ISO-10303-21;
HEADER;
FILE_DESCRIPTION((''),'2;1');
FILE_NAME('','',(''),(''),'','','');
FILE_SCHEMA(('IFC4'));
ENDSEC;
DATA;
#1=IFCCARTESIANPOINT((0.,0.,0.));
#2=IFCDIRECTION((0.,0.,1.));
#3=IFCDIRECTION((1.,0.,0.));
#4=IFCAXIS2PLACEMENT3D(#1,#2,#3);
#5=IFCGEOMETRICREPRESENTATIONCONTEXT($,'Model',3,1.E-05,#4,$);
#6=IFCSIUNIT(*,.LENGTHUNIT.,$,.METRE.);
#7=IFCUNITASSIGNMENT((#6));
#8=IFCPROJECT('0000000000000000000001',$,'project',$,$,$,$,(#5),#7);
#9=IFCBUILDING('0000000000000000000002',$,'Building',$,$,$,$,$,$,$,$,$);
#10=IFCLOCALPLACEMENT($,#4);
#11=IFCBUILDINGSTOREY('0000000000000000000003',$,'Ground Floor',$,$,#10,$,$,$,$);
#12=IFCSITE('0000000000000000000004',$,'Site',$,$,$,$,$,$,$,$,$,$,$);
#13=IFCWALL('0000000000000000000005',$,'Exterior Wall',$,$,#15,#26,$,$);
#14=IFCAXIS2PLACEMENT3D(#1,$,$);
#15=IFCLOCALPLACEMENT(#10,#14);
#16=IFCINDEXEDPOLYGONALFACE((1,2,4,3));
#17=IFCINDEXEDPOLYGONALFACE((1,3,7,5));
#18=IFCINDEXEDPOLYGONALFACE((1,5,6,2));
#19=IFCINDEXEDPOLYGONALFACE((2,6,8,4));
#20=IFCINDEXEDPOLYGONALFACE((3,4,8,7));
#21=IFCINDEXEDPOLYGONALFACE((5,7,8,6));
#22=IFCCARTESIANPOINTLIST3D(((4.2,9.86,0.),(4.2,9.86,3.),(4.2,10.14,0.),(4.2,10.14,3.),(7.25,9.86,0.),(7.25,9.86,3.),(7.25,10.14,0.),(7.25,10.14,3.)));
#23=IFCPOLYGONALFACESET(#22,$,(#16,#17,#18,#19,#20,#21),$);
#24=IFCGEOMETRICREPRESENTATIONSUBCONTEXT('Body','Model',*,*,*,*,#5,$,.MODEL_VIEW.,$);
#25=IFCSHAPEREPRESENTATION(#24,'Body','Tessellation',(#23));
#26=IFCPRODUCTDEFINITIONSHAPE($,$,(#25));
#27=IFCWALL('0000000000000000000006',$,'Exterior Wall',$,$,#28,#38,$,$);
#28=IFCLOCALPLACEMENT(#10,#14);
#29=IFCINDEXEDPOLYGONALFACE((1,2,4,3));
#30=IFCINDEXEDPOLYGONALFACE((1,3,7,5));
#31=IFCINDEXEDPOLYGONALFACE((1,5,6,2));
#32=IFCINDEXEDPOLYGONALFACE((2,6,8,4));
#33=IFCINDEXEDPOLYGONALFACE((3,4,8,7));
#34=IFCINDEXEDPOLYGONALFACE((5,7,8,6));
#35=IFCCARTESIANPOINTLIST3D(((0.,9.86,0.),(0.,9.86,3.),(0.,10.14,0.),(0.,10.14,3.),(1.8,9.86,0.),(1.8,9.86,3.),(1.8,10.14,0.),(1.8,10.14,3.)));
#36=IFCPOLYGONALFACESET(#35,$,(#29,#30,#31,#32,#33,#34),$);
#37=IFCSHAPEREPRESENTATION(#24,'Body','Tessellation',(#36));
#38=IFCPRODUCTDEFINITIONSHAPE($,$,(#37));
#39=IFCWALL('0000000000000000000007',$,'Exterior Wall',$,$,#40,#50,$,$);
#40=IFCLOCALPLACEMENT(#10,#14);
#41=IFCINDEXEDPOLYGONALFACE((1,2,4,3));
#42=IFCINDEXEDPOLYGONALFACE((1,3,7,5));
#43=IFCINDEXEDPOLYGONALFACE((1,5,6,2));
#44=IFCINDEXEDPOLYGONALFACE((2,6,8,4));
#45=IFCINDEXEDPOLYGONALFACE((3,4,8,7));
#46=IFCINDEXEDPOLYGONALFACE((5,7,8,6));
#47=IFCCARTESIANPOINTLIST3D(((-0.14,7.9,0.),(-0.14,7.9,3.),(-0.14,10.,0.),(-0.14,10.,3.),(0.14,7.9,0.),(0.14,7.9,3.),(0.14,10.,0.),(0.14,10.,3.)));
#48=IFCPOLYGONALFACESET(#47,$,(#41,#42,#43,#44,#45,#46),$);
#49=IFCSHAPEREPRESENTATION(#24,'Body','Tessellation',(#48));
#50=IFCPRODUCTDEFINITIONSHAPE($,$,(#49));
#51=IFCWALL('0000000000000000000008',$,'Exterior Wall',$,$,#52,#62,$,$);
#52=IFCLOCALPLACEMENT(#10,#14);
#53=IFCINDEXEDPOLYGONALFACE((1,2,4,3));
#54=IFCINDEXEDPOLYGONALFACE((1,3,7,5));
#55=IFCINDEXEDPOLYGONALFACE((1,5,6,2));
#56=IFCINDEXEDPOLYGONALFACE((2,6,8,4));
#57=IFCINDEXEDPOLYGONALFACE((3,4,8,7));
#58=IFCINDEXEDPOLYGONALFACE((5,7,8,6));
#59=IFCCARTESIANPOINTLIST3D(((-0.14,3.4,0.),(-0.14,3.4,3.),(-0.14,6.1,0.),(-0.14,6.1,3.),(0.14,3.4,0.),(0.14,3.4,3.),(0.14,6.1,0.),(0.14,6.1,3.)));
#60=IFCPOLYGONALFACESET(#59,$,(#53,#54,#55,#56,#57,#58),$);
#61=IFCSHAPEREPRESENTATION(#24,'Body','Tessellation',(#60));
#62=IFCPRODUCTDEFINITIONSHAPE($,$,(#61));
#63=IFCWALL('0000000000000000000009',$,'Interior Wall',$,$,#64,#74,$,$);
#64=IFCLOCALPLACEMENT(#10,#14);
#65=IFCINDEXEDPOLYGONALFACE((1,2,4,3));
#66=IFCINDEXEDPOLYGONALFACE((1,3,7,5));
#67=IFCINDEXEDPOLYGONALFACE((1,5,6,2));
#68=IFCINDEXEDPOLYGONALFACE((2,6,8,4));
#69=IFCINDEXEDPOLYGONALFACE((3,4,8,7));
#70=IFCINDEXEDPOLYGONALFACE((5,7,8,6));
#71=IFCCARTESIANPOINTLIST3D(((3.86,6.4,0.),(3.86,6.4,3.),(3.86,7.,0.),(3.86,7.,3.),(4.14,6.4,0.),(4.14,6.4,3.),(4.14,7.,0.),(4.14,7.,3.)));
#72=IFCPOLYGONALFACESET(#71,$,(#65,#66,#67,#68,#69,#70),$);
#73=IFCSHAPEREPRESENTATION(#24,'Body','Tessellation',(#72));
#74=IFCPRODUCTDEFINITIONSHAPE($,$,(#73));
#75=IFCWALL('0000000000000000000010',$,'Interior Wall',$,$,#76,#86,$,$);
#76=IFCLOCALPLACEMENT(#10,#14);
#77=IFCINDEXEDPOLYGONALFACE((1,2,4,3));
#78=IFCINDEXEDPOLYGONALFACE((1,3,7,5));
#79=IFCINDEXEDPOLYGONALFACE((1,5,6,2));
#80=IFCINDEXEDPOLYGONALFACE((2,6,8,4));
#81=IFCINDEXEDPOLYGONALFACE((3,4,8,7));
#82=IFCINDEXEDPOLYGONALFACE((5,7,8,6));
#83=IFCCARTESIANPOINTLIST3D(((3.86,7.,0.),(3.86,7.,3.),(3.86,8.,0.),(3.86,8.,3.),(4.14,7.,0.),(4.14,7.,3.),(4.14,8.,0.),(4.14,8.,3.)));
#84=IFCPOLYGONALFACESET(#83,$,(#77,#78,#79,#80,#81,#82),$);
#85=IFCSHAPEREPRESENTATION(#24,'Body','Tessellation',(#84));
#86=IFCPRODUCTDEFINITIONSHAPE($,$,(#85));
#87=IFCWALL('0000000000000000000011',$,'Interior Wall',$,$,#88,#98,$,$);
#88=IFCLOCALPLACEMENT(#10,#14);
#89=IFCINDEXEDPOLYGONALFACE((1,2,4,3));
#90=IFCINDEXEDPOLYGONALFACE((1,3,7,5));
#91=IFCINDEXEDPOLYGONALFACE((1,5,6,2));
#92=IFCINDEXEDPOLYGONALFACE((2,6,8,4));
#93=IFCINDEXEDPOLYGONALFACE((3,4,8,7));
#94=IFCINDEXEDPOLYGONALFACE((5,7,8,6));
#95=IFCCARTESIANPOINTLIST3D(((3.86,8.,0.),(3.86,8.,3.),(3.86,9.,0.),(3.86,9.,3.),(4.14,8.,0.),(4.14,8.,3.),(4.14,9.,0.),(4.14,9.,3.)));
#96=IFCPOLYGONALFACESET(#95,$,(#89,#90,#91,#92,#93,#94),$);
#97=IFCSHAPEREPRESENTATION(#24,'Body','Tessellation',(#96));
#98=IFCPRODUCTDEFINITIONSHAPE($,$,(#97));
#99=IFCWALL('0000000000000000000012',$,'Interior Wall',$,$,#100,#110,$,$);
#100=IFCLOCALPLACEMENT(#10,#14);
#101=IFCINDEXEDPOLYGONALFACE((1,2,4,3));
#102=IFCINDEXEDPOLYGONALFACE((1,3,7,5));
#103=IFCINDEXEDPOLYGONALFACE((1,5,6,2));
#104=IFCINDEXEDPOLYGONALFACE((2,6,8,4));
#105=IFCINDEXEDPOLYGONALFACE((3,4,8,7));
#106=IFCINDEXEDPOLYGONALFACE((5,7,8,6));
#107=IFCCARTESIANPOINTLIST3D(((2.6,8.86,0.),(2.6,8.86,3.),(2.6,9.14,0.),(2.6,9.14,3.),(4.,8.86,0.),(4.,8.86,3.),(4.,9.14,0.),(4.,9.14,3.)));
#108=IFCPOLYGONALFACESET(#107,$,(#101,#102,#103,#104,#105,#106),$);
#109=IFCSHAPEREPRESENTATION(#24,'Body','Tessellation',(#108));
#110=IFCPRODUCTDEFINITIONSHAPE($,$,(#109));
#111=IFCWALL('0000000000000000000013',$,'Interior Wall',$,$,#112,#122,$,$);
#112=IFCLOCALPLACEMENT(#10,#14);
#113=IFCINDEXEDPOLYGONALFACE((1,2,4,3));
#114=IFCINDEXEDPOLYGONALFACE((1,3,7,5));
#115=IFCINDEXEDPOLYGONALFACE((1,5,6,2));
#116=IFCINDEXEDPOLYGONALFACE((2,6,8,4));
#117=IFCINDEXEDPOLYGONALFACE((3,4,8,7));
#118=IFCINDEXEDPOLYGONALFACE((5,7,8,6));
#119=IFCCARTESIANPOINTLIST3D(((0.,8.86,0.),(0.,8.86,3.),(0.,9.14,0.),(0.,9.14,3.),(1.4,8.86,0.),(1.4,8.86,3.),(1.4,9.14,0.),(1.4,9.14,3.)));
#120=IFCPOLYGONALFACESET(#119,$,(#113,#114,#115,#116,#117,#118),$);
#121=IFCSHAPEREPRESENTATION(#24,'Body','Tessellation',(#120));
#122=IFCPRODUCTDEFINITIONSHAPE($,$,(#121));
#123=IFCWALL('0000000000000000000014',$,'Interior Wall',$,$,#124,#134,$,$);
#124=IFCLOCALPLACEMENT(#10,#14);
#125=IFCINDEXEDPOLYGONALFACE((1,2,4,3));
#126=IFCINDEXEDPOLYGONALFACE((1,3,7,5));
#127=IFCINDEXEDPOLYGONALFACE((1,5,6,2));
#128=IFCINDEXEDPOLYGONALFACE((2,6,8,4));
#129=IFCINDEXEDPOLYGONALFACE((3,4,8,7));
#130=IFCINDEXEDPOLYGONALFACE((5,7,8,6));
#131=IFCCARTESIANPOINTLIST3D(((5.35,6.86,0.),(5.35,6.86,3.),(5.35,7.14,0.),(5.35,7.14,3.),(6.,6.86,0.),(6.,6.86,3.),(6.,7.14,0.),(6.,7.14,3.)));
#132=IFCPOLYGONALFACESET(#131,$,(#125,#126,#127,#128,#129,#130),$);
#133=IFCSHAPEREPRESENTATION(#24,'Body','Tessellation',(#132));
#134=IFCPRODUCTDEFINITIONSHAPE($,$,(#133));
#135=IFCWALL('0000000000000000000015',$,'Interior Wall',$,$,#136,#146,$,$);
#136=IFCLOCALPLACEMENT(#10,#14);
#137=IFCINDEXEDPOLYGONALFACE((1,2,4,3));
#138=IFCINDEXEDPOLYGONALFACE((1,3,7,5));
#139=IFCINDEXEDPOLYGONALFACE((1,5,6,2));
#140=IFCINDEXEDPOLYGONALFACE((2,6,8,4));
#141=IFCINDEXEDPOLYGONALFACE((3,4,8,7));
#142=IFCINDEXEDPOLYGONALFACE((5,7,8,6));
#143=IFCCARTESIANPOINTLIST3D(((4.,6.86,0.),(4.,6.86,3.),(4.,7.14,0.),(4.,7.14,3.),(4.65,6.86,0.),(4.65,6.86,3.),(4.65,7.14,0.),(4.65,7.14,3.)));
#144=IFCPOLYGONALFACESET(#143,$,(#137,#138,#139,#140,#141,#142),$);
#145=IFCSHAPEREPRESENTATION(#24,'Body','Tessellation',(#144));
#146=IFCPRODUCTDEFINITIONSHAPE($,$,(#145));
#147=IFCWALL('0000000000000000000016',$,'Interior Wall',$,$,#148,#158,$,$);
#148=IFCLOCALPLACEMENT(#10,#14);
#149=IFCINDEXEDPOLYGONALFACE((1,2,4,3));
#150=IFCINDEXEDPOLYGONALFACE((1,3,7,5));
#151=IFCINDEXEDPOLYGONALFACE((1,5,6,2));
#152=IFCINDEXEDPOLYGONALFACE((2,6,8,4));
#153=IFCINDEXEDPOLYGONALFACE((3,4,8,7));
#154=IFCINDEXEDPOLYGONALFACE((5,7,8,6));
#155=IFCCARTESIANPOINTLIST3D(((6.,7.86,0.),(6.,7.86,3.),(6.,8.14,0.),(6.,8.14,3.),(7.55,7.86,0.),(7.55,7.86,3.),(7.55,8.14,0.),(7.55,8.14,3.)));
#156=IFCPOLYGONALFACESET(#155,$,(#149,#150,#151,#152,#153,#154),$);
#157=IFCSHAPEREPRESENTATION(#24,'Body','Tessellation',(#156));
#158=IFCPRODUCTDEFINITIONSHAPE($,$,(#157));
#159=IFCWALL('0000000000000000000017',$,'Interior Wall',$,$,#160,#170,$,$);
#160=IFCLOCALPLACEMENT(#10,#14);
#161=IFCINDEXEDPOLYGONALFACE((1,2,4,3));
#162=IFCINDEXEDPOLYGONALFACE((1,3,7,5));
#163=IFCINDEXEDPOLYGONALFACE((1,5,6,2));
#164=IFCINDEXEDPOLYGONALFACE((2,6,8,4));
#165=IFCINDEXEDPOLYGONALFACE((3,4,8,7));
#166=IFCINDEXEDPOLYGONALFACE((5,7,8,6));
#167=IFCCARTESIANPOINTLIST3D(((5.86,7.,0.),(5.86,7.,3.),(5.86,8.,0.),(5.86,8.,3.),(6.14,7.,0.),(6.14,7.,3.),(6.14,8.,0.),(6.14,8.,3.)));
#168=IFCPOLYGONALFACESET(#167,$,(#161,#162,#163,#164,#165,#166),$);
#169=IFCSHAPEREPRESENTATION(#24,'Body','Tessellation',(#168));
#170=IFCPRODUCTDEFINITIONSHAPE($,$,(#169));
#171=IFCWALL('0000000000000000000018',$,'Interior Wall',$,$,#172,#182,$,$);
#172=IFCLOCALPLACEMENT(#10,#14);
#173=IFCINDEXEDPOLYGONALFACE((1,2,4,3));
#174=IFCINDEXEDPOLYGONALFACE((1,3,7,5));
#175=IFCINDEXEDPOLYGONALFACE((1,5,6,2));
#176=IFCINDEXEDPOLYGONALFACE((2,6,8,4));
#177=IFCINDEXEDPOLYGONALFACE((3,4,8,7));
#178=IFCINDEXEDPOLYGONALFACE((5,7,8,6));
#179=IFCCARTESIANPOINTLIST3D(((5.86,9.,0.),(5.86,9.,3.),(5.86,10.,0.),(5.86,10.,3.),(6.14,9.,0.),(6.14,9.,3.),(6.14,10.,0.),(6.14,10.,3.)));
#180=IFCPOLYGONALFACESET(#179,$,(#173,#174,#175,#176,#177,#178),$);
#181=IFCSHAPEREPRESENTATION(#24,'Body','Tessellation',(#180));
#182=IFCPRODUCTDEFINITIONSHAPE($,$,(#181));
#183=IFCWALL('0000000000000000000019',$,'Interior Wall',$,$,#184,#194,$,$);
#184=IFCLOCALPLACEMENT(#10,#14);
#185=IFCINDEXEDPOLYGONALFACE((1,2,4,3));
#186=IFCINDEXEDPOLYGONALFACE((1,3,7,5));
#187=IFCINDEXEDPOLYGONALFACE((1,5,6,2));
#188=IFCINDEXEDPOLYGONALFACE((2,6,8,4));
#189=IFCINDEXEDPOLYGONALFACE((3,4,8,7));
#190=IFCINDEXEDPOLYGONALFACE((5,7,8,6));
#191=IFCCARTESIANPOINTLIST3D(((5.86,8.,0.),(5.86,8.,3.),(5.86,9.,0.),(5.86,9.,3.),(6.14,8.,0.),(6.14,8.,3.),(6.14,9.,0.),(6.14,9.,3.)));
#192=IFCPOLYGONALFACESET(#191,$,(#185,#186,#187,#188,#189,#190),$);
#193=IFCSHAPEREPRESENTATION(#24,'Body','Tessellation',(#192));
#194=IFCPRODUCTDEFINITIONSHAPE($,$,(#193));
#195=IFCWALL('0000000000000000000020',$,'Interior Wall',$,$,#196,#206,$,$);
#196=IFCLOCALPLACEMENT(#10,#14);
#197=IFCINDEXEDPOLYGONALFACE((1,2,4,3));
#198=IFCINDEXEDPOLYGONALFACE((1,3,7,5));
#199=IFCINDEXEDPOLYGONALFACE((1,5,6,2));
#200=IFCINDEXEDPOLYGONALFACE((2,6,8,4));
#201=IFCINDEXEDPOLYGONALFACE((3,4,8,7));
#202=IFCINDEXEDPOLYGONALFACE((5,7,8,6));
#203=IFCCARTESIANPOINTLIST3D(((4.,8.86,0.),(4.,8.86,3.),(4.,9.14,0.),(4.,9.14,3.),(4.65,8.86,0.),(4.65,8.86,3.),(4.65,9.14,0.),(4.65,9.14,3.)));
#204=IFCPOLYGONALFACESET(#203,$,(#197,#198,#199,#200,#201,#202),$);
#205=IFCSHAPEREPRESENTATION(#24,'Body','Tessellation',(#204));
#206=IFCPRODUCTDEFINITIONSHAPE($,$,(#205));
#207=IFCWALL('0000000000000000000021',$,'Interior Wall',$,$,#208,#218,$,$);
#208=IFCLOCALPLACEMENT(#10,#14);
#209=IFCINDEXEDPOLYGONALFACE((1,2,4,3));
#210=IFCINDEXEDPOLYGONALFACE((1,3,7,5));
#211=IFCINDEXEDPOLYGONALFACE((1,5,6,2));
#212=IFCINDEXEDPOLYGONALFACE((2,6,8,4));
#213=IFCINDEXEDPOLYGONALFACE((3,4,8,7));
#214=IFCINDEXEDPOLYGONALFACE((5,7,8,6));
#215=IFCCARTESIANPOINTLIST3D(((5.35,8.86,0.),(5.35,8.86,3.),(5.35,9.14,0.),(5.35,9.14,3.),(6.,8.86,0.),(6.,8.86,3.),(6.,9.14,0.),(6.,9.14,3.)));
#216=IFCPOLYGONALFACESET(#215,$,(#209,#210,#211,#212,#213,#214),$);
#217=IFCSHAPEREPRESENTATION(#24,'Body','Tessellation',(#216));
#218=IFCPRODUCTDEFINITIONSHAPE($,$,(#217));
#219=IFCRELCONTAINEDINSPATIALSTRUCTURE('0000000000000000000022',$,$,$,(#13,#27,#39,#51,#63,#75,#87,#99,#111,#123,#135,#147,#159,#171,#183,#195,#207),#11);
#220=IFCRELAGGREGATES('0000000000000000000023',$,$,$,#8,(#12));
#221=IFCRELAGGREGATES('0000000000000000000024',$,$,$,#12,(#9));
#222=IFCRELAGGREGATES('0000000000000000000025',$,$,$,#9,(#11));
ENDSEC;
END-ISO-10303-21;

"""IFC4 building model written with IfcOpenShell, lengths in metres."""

from ifc_helpers import new_model, si_unit, frame, origin_with_axes, place, context, subcontext, project, spatial, indexed_curve, outline, extrude, element, save


model = new_model("IFC4")

# Units and contexts
model_context = context("Model", 3, precision=1e-05, world=origin_with_axes())
body_context = subcontext(model_context, "Body", "Model", "MODEL_VIEW")
ifc_project = project(units=[si_unit("LENGTHUNIT", "METRE")], contexts=[model_context])

# Site, building, storey
site = spatial("IfcSite", under=ifc_project, Name="Site")
building = spatial("IfcBuilding", under=site, Name="Building")
storey_placement = place(None, origin_with_axes())
storey = spatial("IfcBuildingStorey", under=building, at=storey_placement, Name="Ground Floor")

# Walls
wall_1_placement = place(storey_placement, frame((7.25, 10.0, 0.0), z_axis=(0.0, 0.0, 1.0), x_axis=(-1.0, 0.0, 0.0)))
element("IfcWall", 1, at=wall_1_placement, inside=storey, Name="Exterior Wall", context=body_context, shape_type="SweptSolid", body=[
    extrude(outline(indexed_curve([(0.0, 0.0), (0.0, 0.28), (3.05, 0.28), (3.05, 0.0), (0.0, 0.0)], self_intersect=False)), frame((0.0, -0.14, 0.0), z_axis=(0.0, 0.0, 1.0), x_axis=(1.0, 0.0, 0.0)), (0.0, 0.0, 1.0), 3.0),
])
wall_2_placement = place(storey_placement, frame((1.8, 10.0, 0.0), z_axis=(0.0, 0.0, 1.0), x_axis=(-1.0, 0.0, 0.0)))
element("IfcWall", 2, at=wall_2_placement, inside=storey, Name="Exterior Wall", context=body_context, shape_type="SweptSolid", body=[
    extrude(outline(indexed_curve([(0.0, 0.0), (0.0, 0.28), (1.8, 0.28), (1.8, 0.0), (0.0, 0.0)], self_intersect=False)), frame((0.0, -0.14, 0.0), z_axis=(0.0, 0.0, 1.0), x_axis=(1.0, 0.0, 0.0)), (0.0, 0.0, 1.0), 3.0),
])
wall_3_placement = place(storey_placement, frame((0.0, 10.0, 0.0), z_axis=(0.0, 0.0, 1.0), x_axis=(0.0, -1.0, 0.0)))
element("IfcWall", 3, at=wall_3_placement, inside=storey, Name="Exterior Wall", context=body_context, shape_type="SweptSolid", body=[
    extrude(outline(indexed_curve([(0.0, 0.0), (0.0, 0.28), (2.1, 0.28), (2.1, 0.0), (0.0, 0.0)], self_intersect=False)), frame((0.0, -0.14, 0.0), z_axis=(0.0, 0.0, 1.0), x_axis=(1.0, 0.0, 0.0)), (0.0, 0.0, 1.0), 3.0),
])
wall_4_placement = place(storey_placement, frame((0.0, 6.1, 0.0), z_axis=(0.0, 0.0, 1.0), x_axis=(0.0, -1.0, 0.0)))
element("IfcWall", 4, at=wall_4_placement, inside=storey, Name="Exterior Wall", context=body_context, shape_type="SweptSolid", body=[
    extrude(outline(indexed_curve([(0.0, 0.0), (0.0, 0.28), (2.7, 0.28), (2.7, 0.0), (0.0, 0.0)], self_intersect=False)), frame((0.0, -0.14, 0.0), z_axis=(0.0, 0.0, 1.0), x_axis=(1.0, 0.0, 0.0)), (0.0, 0.0, 1.0), 3.0),
])
wall_5_placement = place(storey_placement, frame((4.0, 6.4, 0.0), z_axis=(0.0, 0.0, 1.0), x_axis=(0.0, 1.0, 0.0)))
element("IfcWall", 5, at=wall_5_placement, inside=storey, Name="Interior Wall", context=body_context, shape_type="SweptSolid", body=[
    extrude(outline(indexed_curve([(0.0, 0.0), (0.0, 0.28), (0.6, 0.28), (0.6, 0.0), (0.0, 0.0)], self_intersect=False)), frame((0.0, -0.14, 0.0), z_axis=(0.0, 0.0, 1.0), x_axis=(1.0, 0.0, 0.0)), (0.0, 0.0, 1.0), 3.0),
])
for number, where, z_axis, x_axis, name in (
    (6, (4.0, 7.0, 0.0), (0.0, 0.0, 1.0), (0.0, 1.0, 0.0), "Interior Wall"),
    (7, (4.0, 8.0, 0.0), (0.0, 0.0, 1.0), (0.0, 1.0, 0.0), "Interior Wall"),
):
    element("IfcWall", number, at=place(storey_placement, frame(where, z_axis=z_axis, x_axis=x_axis)), inside=storey, Name=name, context=body_context, shape_type="SweptSolid", body=[
        extrude(outline(indexed_curve([(0.0, 0.0), (0.0, 0.28), (1.0, 0.28), (1.0, 0.0), (0.0, 0.0)], self_intersect=False)), frame((0.0, -0.14, 0.0), z_axis=(0.0, 0.0, 1.0), x_axis=(1.0, 0.0, 0.0)), (0.0, 0.0, 1.0), 3.0),
    ])
for number, where, z_axis, x_axis, name in (
    (8, (4.0, 9.0, 0.0), (0.0, 0.0, 1.0), (-1.0, 0.0, 0.0), "Interior Wall"),
    (9, (1.4, 9.0, 0.0), (0.0, 0.0, 1.0), (-1.0, 0.0, 0.0), "Interior Wall"),
):
    element("IfcWall", number, at=place(storey_placement, frame(where, z_axis=z_axis, x_axis=x_axis)), inside=storey, Name=name, context=body_context, shape_type="SweptSolid", body=[
        extrude(outline(indexed_curve([(0.0, 0.0), (0.0, 0.28), (1.4, 0.28), (1.4, 0.0), (0.0, 0.0)], self_intersect=False)), frame((0.0, -0.14, 0.0), z_axis=(0.0, 0.0, 1.0), x_axis=(1.0, 0.0, 0.0)), (0.0, 0.0, 1.0), 3.0),
    ])
for number, where, z_axis, x_axis, name in (
    (10, (6.0, 7.0, 0.0), (0.0, 0.0, 1.0), (-1.0, 0.0, 0.0), "Interior Wall"),
    (11, (4.65, 7.0, 0.0), (0.0, 0.0, 1.0), (-1.0, 0.0, 0.0), "Interior Wall"),
):
    element("IfcWall", number, at=place(storey_placement, frame(where, z_axis=z_axis, x_axis=x_axis)), inside=storey, Name=name, context=body_context, shape_type="SweptSolid", body=[
        extrude(outline(indexed_curve([(0.0, 0.0), (0.0, 0.28), (0.65, 0.28), (0.65, 0.0), (0.0, 0.0)], self_intersect=False)), frame((0.0, -0.14, 0.0), z_axis=(0.0, 0.0, 1.0), x_axis=(1.0, 0.0, 0.0)), (0.0, 0.0, 1.0), 3.0),
    ])
wall_6_placement = place(storey_placement, frame((7.55, 8.0, 0.0), z_axis=(0.0, 0.0, 1.0), x_axis=(-1.0, 0.0, 0.0)))
element("IfcWall", 12, at=wall_6_placement, inside=storey, Name="Interior Wall", context=body_context, shape_type="SweptSolid", body=[
    extrude(outline(indexed_curve([(0.0, 0.0), (0.0, 0.28), (1.55, 0.28), (1.55, 0.0), (0.0, 0.0)], self_intersect=False)), frame((0.0, -0.14, 0.0), z_axis=(0.0, 0.0, 1.0), x_axis=(1.0, 0.0, 0.0)), (0.0, 0.0, 1.0), 3.0),
])
for number, where, z_axis, x_axis, name in (
    (13, (6.0, 8.0, 0.0), (0.0, 0.0, 1.0), (0.0, -1.0, 0.0), "Interior Wall"),
    (14, (6.0, 10.0, 0.0), (0.0, 0.0, 1.0), (0.0, -1.0, 0.0), "Interior Wall"),
    (15, (6.0, 9.0, 0.0), (0.0, 0.0, 1.0), (0.0, -1.0, 0.0), "Interior Wall"),
):
    element("IfcWall", number, at=place(storey_placement, frame(where, z_axis=z_axis, x_axis=x_axis)), inside=storey, Name=name, context=body_context, shape_type="SweptSolid", body=[
        extrude(outline(indexed_curve([(0.0, 0.0), (0.0, 0.28), (1.0, 0.28), (1.0, 0.0), (0.0, 0.0)], self_intersect=False)), frame((0.0, -0.14, 0.0), z_axis=(0.0, 0.0, 1.0), x_axis=(1.0, 0.0, 0.0)), (0.0, 0.0, 1.0), 3.0),
    ])
for number, where, z_axis, x_axis, name in (
    (16, (4.0, 9.0, 0.0), (0.0, 0.0, 1.0), (1.0, 0.0, 0.0), "Interior Wall"),
    (17, (5.35, 9.0, 0.0), (0.0, 0.0, 1.0), (1.0, 0.0, 0.0), "Interior Wall"),
):
    element("IfcWall", number, at=place(storey_placement, frame(where, z_axis=z_axis, x_axis=x_axis)), inside=storey, Name=name, context=body_context, shape_type="SweptSolid", body=[
        extrude(outline(indexed_curve([(0.0, 0.0), (0.0, 0.28), (0.65, 0.28), (0.65, 0.0), (0.0, 0.0)], self_intersect=False)), frame((0.0, -0.14, 0.0), z_axis=(0.0, 0.0, 1.0), x_axis=(1.0, 0.0, 0.0)), (0.0, 0.0, 1.0), 3.0),
    ])

save(model, "model.ifc")
